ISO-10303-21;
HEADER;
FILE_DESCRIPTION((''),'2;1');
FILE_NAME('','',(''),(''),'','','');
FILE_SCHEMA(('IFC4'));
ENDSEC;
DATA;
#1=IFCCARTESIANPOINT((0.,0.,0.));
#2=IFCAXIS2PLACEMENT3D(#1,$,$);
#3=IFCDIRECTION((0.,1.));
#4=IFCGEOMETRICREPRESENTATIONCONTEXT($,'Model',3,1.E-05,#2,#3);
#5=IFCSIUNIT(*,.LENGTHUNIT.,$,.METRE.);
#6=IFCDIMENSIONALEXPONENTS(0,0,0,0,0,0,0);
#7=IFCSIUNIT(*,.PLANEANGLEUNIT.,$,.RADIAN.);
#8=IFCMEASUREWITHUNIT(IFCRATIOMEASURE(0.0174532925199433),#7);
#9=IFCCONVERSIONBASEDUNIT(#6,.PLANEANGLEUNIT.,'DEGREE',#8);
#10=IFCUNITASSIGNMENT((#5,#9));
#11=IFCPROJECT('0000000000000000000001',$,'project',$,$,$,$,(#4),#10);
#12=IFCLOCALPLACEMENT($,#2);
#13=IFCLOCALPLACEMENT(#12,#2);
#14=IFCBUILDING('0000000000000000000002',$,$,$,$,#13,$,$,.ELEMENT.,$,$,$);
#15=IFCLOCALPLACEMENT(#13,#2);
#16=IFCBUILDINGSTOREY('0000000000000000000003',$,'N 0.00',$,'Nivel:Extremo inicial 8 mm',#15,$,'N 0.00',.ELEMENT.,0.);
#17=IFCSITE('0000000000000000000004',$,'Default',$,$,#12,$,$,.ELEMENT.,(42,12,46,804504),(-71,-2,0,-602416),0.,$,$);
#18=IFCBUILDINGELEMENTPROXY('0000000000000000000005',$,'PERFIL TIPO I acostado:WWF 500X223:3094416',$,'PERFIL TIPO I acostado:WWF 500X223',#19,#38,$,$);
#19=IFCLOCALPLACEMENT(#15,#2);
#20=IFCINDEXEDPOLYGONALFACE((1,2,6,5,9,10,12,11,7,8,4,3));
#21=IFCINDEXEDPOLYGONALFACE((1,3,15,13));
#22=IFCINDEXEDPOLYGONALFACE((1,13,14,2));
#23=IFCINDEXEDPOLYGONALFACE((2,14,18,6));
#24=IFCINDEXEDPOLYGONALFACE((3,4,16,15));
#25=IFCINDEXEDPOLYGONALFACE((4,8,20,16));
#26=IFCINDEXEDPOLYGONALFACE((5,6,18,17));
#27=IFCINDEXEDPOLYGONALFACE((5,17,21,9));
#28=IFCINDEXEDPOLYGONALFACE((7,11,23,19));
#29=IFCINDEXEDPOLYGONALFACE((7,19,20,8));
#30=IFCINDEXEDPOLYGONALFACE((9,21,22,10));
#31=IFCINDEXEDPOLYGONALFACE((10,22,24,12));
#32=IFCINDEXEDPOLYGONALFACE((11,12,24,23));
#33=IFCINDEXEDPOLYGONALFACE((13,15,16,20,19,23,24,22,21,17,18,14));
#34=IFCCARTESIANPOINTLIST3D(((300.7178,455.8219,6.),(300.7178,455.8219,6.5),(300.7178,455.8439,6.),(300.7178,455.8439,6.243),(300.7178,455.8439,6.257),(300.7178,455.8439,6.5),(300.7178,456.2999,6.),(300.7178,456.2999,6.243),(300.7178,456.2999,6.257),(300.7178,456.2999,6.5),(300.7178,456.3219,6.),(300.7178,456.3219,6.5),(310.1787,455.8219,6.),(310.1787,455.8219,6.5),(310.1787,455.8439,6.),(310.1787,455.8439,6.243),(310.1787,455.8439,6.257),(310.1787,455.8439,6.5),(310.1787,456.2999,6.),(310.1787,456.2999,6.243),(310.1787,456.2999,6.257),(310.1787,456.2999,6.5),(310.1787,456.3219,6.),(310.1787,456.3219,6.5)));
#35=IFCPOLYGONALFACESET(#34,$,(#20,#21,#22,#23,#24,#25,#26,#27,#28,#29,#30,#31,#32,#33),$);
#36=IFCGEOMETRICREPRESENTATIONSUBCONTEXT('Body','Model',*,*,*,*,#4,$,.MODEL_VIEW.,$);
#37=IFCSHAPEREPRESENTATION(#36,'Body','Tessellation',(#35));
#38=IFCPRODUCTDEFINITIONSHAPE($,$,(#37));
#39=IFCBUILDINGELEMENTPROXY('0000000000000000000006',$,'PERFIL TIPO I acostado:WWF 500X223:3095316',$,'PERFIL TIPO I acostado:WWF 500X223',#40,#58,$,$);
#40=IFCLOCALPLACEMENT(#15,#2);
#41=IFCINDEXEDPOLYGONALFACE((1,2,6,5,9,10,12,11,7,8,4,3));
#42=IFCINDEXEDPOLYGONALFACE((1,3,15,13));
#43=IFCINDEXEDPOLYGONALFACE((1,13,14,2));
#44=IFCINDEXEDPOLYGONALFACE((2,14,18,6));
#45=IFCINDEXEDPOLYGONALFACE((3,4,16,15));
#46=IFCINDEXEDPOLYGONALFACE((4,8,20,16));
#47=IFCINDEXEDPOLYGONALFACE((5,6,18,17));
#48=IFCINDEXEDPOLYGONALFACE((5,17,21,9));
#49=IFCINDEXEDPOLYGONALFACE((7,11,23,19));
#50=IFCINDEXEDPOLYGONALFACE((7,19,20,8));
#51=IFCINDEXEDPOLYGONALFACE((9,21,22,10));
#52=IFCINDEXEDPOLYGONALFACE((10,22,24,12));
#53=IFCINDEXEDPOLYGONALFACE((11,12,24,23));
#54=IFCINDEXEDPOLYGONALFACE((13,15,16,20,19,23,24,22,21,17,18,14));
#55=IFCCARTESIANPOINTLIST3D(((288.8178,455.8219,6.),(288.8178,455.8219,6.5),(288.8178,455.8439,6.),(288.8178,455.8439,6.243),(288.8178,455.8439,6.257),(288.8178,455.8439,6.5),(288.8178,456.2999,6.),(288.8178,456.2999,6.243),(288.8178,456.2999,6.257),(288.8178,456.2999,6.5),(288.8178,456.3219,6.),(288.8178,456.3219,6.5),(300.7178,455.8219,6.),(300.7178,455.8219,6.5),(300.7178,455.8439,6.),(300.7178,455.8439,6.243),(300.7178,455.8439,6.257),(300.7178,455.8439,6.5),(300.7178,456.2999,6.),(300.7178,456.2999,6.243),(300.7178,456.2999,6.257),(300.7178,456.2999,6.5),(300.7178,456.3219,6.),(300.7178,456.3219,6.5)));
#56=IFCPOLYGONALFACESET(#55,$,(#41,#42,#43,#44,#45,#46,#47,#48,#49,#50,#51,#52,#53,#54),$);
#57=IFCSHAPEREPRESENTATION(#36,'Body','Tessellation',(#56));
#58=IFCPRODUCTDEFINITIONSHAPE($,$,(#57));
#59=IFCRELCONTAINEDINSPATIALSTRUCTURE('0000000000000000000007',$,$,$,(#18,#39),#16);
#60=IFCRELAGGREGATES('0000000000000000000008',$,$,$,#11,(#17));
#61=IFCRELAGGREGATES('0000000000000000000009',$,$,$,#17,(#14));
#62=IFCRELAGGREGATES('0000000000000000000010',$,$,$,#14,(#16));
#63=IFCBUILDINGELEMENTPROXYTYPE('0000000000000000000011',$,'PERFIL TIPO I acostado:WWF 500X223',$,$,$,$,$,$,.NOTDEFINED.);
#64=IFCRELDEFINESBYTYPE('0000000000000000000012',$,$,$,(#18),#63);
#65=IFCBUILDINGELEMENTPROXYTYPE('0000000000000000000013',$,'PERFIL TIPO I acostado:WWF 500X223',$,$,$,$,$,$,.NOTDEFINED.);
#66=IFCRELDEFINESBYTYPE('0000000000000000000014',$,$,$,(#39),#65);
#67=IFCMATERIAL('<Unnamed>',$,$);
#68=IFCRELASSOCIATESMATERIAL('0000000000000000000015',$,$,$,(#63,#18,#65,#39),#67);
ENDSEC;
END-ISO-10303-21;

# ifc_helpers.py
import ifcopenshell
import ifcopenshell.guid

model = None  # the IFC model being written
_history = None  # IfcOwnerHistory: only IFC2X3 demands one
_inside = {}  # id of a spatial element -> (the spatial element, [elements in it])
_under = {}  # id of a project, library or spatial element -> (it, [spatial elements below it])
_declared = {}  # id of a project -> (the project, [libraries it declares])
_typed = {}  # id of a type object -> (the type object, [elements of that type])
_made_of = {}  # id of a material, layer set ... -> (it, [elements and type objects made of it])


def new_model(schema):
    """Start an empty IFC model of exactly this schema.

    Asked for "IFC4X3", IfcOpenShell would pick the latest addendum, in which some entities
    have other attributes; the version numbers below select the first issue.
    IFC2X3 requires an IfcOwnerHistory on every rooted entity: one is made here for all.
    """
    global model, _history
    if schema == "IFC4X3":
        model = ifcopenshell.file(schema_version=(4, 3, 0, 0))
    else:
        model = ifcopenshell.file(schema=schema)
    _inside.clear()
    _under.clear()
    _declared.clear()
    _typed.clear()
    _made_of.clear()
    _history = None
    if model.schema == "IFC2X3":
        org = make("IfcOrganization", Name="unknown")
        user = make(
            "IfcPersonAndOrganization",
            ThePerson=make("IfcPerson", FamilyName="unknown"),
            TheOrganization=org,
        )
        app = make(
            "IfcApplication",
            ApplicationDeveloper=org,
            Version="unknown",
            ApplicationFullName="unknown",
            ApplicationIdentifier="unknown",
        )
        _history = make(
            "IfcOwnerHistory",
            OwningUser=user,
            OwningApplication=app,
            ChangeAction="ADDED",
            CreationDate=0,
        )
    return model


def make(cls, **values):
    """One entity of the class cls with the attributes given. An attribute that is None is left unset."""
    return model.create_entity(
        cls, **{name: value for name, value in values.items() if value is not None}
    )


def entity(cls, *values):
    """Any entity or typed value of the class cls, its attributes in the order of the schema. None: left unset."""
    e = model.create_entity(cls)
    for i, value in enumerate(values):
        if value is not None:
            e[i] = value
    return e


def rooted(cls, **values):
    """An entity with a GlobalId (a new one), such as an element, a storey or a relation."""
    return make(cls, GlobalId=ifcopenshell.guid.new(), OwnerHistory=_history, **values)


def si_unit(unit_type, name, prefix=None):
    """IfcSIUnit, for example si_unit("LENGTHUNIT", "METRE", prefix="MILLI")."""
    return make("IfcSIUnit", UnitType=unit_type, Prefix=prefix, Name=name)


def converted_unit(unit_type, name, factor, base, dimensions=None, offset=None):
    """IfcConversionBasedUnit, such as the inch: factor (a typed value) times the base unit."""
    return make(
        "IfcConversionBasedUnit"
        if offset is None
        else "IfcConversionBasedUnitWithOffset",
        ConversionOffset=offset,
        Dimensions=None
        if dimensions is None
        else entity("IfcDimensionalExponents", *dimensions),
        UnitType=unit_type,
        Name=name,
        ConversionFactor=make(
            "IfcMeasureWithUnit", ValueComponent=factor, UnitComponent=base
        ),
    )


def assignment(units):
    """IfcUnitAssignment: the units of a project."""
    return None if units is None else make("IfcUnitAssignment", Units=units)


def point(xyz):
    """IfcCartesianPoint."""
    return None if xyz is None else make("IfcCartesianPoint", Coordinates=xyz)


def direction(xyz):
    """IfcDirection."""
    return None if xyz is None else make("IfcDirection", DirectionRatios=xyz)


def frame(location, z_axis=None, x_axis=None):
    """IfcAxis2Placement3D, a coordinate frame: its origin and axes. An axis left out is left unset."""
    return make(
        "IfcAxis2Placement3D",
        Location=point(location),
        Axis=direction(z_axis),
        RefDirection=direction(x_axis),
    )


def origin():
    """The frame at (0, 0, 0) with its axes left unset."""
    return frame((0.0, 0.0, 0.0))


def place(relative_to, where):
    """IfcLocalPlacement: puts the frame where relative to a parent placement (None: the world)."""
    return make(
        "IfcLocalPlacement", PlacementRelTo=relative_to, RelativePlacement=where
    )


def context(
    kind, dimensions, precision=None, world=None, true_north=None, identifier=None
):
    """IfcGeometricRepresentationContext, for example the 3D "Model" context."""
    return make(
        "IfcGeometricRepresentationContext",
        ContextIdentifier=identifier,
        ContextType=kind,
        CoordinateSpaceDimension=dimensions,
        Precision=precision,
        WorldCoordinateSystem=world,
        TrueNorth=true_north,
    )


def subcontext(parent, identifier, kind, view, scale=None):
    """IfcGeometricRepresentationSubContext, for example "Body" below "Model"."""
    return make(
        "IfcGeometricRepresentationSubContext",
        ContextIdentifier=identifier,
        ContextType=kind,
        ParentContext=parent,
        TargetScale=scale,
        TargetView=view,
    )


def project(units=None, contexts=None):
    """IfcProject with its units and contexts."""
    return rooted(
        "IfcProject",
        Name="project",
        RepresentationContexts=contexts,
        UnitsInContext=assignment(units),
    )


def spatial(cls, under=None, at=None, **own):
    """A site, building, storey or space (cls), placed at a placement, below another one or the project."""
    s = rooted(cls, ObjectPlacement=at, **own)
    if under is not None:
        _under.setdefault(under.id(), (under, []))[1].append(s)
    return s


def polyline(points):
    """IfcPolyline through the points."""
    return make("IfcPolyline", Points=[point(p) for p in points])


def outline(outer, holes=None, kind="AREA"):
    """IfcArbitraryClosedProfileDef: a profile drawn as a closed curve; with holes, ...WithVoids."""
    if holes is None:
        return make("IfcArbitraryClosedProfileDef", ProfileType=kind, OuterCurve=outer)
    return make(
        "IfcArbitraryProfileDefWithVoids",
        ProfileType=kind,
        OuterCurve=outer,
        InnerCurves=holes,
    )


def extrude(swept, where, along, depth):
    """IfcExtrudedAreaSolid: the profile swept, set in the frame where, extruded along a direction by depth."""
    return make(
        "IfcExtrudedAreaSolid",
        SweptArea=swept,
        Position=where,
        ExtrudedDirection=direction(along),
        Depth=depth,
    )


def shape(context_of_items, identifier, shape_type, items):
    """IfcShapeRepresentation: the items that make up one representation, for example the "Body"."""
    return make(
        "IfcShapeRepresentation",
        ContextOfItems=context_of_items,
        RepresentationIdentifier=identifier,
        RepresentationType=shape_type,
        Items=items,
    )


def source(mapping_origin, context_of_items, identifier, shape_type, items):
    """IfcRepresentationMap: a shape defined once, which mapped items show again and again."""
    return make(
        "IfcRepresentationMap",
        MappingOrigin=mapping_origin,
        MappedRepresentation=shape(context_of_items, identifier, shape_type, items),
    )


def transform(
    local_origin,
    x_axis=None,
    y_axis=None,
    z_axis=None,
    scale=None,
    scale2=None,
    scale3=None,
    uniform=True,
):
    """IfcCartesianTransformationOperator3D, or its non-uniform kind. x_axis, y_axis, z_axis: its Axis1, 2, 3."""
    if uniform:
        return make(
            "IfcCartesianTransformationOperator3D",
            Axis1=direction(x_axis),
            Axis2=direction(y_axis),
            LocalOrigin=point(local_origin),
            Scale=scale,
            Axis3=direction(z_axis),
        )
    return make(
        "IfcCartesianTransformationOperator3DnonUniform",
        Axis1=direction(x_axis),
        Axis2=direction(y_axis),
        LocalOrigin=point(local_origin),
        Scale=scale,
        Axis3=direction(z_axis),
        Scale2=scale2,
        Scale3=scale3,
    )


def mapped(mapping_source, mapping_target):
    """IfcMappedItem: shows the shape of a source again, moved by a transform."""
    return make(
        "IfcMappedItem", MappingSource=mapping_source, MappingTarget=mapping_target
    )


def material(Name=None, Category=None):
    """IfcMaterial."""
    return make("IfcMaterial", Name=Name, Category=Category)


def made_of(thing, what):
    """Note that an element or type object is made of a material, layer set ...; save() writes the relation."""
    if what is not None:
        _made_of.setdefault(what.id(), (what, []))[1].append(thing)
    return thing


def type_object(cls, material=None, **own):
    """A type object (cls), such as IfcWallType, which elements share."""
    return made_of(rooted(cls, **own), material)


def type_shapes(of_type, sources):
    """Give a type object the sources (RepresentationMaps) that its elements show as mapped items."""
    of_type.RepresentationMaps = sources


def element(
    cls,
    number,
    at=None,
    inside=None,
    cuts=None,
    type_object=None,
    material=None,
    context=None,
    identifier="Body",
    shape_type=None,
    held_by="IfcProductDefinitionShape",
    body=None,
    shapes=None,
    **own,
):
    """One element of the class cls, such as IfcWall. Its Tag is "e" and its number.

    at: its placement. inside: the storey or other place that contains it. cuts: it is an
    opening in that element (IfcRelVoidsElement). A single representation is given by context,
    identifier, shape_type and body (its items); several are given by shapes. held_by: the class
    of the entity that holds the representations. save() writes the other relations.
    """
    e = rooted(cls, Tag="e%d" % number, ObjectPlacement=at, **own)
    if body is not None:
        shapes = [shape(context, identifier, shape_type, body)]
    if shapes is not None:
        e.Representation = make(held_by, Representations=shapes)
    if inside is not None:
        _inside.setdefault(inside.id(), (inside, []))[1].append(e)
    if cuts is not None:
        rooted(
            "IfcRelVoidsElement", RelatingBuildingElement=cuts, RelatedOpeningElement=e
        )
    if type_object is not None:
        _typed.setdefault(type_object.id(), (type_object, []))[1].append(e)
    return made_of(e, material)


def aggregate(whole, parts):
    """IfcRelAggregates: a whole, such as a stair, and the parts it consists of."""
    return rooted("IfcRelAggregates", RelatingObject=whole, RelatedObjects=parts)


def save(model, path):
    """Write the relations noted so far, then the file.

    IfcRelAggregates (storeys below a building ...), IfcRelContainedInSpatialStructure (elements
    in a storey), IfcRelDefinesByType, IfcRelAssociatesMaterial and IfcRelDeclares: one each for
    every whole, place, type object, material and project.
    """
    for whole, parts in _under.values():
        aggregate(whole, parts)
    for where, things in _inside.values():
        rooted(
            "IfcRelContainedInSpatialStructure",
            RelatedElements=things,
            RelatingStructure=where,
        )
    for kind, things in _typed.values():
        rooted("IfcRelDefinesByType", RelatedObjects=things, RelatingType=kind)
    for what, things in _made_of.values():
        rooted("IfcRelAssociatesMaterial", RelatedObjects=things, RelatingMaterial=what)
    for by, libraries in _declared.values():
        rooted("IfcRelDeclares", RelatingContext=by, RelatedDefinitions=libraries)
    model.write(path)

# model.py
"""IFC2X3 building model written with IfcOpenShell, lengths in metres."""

from ifc_helpers import new_model, entity, si_unit, converted_unit, direction, frame, origin, place, context, subcontext, project, spatial, polyline, outline, extrude, source, transform, mapped, material, type_object, type_shapes, element, save


model = new_model("IFC2X3")

# Units and contexts
model_context = context("Model", 3, precision=1e-05, world=origin(), true_north=direction((0.0, 1.0)))
body_context = subcontext(model_context, "Body", "Model", "MODEL_VIEW")
ifc_project = project(units=[si_unit("LENGTHUNIT", "METRE"), converted_unit("PLANEANGLEUNIT", "DEGREE", entity("IfcRatioMeasure", 0.0174532925199433), si_unit("PLANEANGLEUNIT", "RADIAN"), dimensions=[0, 0, 0, 0, 0, 0, 0])], contexts=[model_context])

# Site, building, storey
site_placement = place(None, origin())
site = spatial("IfcSite", under=ifc_project, at=site_placement, Name="Default", CompositionType="ELEMENT", RefLatitude=(42, 12, 46, 804504), RefLongitude=(-71, -2, 0, -602416), RefElevation=0.0)
building_placement = place(site_placement, origin())
building = spatial("IfcBuilding", under=site, at=building_placement, CompositionType="ELEMENT")
storey_placement = place(building_placement, origin())
storey = spatial("IfcBuildingStorey", under=building, at=storey_placement, Name="N 0.00", ObjectType="Nivel:Extremo inicial 8 mm", LongName="N 0.00", CompositionType="ELEMENT", Elevation=0.0)

# Shared definitions
ifc_material_1 = material(Name="<Unnamed>")

# Building element proxies
building_element_proxy_type_1 = type_object("IfcBuildingElementProxyType", Name="PERFIL TIPO I acostado:WWF 500X223", PredefinedType="NOTDEFINED", material=ifc_material_1)
shared_shape_1 = source(origin(), body_context, "Body", "SweptSolid", [
    extrude(outline(polyline([(-0.25, -0.228), (-0.25, -0.25), (0.25, -0.25), (0.25, -0.228), (0.007, -0.228), (0.007, 0.228), (0.25, 0.228), (0.25, 0.25), (-0.25, 0.25), (-0.25, 0.228), (-0.007, 0.228), (-0.007, -0.228), (-0.25, -0.228)])), frame((0.0, 0.0, 0.25), z_axis=(-1.0, 0.0, 0.0), x_axis=(0.0, 0.0, -1.0)), (0.0, 0.0, -1.0), 9.461),
])
type_shapes(building_element_proxy_type_1, [shared_shape_1])
proxy_1_placement = place(storey_placement, frame((310.1787, 456.0719, 6.0), z_axis=(0.0, 0.0, 1.0), x_axis=(-1.0, 0.0, 0.0)))
element("IfcBuildingElementProxy", 1, at=proxy_1_placement, inside=storey, type_object=building_element_proxy_type_1, material=ifc_material_1, Name="PERFIL TIPO I acostado:WWF 500X223:3094416", ObjectType="PERFIL TIPO I acostado:WWF 500X223", context=body_context, shape_type="MappedRepresentation", body=[
    mapped(shared_shape_1, transform((0.0, 0.0, 0.0), scale=1.0)),
])
building_element_proxy_type_2 = type_object("IfcBuildingElementProxyType", Name="PERFIL TIPO I acostado:WWF 500X223", PredefinedType="NOTDEFINED", material=ifc_material_1)
shared_shape_2 = source(origin(), body_context, "Body", "SweptSolid", [
    extrude(outline(polyline([(-0.25, -0.228), (-0.25, -0.25), (0.25, -0.25), (0.25, -0.228), (0.007, -0.228), (0.007, 0.228), (0.25, 0.228), (0.25, 0.25), (-0.25, 0.25), (-0.25, 0.228), (-0.007, 0.228), (-0.007, -0.228), (-0.25, -0.228)])), frame((0.0, 0.0, 0.25), z_axis=(-1.0, 0.0, 0.0), x_axis=(0.0, 0.0, -1.0)), (0.0, 0.0, -1.0), 11.9),
])
type_shapes(building_element_proxy_type_2, [shared_shape_2])
proxy_2_placement = place(storey_placement, frame((300.7178, 456.0719, 6.0), z_axis=(0.0, 0.0, 1.0), x_axis=(-1.0, 0.0, 0.0)))
element("IfcBuildingElementProxy", 2, at=proxy_2_placement, inside=storey, type_object=building_element_proxy_type_2, material=ifc_material_1, Name="PERFIL TIPO I acostado:WWF 500X223:3095316", ObjectType="PERFIL TIPO I acostado:WWF 500X223", context=body_context, shape_type="MappedRepresentation", body=[
    mapped(shared_shape_2, transform((0.0, 0.0, 0.0), scale=1.0)),
])

save(model, "model.ifc")
